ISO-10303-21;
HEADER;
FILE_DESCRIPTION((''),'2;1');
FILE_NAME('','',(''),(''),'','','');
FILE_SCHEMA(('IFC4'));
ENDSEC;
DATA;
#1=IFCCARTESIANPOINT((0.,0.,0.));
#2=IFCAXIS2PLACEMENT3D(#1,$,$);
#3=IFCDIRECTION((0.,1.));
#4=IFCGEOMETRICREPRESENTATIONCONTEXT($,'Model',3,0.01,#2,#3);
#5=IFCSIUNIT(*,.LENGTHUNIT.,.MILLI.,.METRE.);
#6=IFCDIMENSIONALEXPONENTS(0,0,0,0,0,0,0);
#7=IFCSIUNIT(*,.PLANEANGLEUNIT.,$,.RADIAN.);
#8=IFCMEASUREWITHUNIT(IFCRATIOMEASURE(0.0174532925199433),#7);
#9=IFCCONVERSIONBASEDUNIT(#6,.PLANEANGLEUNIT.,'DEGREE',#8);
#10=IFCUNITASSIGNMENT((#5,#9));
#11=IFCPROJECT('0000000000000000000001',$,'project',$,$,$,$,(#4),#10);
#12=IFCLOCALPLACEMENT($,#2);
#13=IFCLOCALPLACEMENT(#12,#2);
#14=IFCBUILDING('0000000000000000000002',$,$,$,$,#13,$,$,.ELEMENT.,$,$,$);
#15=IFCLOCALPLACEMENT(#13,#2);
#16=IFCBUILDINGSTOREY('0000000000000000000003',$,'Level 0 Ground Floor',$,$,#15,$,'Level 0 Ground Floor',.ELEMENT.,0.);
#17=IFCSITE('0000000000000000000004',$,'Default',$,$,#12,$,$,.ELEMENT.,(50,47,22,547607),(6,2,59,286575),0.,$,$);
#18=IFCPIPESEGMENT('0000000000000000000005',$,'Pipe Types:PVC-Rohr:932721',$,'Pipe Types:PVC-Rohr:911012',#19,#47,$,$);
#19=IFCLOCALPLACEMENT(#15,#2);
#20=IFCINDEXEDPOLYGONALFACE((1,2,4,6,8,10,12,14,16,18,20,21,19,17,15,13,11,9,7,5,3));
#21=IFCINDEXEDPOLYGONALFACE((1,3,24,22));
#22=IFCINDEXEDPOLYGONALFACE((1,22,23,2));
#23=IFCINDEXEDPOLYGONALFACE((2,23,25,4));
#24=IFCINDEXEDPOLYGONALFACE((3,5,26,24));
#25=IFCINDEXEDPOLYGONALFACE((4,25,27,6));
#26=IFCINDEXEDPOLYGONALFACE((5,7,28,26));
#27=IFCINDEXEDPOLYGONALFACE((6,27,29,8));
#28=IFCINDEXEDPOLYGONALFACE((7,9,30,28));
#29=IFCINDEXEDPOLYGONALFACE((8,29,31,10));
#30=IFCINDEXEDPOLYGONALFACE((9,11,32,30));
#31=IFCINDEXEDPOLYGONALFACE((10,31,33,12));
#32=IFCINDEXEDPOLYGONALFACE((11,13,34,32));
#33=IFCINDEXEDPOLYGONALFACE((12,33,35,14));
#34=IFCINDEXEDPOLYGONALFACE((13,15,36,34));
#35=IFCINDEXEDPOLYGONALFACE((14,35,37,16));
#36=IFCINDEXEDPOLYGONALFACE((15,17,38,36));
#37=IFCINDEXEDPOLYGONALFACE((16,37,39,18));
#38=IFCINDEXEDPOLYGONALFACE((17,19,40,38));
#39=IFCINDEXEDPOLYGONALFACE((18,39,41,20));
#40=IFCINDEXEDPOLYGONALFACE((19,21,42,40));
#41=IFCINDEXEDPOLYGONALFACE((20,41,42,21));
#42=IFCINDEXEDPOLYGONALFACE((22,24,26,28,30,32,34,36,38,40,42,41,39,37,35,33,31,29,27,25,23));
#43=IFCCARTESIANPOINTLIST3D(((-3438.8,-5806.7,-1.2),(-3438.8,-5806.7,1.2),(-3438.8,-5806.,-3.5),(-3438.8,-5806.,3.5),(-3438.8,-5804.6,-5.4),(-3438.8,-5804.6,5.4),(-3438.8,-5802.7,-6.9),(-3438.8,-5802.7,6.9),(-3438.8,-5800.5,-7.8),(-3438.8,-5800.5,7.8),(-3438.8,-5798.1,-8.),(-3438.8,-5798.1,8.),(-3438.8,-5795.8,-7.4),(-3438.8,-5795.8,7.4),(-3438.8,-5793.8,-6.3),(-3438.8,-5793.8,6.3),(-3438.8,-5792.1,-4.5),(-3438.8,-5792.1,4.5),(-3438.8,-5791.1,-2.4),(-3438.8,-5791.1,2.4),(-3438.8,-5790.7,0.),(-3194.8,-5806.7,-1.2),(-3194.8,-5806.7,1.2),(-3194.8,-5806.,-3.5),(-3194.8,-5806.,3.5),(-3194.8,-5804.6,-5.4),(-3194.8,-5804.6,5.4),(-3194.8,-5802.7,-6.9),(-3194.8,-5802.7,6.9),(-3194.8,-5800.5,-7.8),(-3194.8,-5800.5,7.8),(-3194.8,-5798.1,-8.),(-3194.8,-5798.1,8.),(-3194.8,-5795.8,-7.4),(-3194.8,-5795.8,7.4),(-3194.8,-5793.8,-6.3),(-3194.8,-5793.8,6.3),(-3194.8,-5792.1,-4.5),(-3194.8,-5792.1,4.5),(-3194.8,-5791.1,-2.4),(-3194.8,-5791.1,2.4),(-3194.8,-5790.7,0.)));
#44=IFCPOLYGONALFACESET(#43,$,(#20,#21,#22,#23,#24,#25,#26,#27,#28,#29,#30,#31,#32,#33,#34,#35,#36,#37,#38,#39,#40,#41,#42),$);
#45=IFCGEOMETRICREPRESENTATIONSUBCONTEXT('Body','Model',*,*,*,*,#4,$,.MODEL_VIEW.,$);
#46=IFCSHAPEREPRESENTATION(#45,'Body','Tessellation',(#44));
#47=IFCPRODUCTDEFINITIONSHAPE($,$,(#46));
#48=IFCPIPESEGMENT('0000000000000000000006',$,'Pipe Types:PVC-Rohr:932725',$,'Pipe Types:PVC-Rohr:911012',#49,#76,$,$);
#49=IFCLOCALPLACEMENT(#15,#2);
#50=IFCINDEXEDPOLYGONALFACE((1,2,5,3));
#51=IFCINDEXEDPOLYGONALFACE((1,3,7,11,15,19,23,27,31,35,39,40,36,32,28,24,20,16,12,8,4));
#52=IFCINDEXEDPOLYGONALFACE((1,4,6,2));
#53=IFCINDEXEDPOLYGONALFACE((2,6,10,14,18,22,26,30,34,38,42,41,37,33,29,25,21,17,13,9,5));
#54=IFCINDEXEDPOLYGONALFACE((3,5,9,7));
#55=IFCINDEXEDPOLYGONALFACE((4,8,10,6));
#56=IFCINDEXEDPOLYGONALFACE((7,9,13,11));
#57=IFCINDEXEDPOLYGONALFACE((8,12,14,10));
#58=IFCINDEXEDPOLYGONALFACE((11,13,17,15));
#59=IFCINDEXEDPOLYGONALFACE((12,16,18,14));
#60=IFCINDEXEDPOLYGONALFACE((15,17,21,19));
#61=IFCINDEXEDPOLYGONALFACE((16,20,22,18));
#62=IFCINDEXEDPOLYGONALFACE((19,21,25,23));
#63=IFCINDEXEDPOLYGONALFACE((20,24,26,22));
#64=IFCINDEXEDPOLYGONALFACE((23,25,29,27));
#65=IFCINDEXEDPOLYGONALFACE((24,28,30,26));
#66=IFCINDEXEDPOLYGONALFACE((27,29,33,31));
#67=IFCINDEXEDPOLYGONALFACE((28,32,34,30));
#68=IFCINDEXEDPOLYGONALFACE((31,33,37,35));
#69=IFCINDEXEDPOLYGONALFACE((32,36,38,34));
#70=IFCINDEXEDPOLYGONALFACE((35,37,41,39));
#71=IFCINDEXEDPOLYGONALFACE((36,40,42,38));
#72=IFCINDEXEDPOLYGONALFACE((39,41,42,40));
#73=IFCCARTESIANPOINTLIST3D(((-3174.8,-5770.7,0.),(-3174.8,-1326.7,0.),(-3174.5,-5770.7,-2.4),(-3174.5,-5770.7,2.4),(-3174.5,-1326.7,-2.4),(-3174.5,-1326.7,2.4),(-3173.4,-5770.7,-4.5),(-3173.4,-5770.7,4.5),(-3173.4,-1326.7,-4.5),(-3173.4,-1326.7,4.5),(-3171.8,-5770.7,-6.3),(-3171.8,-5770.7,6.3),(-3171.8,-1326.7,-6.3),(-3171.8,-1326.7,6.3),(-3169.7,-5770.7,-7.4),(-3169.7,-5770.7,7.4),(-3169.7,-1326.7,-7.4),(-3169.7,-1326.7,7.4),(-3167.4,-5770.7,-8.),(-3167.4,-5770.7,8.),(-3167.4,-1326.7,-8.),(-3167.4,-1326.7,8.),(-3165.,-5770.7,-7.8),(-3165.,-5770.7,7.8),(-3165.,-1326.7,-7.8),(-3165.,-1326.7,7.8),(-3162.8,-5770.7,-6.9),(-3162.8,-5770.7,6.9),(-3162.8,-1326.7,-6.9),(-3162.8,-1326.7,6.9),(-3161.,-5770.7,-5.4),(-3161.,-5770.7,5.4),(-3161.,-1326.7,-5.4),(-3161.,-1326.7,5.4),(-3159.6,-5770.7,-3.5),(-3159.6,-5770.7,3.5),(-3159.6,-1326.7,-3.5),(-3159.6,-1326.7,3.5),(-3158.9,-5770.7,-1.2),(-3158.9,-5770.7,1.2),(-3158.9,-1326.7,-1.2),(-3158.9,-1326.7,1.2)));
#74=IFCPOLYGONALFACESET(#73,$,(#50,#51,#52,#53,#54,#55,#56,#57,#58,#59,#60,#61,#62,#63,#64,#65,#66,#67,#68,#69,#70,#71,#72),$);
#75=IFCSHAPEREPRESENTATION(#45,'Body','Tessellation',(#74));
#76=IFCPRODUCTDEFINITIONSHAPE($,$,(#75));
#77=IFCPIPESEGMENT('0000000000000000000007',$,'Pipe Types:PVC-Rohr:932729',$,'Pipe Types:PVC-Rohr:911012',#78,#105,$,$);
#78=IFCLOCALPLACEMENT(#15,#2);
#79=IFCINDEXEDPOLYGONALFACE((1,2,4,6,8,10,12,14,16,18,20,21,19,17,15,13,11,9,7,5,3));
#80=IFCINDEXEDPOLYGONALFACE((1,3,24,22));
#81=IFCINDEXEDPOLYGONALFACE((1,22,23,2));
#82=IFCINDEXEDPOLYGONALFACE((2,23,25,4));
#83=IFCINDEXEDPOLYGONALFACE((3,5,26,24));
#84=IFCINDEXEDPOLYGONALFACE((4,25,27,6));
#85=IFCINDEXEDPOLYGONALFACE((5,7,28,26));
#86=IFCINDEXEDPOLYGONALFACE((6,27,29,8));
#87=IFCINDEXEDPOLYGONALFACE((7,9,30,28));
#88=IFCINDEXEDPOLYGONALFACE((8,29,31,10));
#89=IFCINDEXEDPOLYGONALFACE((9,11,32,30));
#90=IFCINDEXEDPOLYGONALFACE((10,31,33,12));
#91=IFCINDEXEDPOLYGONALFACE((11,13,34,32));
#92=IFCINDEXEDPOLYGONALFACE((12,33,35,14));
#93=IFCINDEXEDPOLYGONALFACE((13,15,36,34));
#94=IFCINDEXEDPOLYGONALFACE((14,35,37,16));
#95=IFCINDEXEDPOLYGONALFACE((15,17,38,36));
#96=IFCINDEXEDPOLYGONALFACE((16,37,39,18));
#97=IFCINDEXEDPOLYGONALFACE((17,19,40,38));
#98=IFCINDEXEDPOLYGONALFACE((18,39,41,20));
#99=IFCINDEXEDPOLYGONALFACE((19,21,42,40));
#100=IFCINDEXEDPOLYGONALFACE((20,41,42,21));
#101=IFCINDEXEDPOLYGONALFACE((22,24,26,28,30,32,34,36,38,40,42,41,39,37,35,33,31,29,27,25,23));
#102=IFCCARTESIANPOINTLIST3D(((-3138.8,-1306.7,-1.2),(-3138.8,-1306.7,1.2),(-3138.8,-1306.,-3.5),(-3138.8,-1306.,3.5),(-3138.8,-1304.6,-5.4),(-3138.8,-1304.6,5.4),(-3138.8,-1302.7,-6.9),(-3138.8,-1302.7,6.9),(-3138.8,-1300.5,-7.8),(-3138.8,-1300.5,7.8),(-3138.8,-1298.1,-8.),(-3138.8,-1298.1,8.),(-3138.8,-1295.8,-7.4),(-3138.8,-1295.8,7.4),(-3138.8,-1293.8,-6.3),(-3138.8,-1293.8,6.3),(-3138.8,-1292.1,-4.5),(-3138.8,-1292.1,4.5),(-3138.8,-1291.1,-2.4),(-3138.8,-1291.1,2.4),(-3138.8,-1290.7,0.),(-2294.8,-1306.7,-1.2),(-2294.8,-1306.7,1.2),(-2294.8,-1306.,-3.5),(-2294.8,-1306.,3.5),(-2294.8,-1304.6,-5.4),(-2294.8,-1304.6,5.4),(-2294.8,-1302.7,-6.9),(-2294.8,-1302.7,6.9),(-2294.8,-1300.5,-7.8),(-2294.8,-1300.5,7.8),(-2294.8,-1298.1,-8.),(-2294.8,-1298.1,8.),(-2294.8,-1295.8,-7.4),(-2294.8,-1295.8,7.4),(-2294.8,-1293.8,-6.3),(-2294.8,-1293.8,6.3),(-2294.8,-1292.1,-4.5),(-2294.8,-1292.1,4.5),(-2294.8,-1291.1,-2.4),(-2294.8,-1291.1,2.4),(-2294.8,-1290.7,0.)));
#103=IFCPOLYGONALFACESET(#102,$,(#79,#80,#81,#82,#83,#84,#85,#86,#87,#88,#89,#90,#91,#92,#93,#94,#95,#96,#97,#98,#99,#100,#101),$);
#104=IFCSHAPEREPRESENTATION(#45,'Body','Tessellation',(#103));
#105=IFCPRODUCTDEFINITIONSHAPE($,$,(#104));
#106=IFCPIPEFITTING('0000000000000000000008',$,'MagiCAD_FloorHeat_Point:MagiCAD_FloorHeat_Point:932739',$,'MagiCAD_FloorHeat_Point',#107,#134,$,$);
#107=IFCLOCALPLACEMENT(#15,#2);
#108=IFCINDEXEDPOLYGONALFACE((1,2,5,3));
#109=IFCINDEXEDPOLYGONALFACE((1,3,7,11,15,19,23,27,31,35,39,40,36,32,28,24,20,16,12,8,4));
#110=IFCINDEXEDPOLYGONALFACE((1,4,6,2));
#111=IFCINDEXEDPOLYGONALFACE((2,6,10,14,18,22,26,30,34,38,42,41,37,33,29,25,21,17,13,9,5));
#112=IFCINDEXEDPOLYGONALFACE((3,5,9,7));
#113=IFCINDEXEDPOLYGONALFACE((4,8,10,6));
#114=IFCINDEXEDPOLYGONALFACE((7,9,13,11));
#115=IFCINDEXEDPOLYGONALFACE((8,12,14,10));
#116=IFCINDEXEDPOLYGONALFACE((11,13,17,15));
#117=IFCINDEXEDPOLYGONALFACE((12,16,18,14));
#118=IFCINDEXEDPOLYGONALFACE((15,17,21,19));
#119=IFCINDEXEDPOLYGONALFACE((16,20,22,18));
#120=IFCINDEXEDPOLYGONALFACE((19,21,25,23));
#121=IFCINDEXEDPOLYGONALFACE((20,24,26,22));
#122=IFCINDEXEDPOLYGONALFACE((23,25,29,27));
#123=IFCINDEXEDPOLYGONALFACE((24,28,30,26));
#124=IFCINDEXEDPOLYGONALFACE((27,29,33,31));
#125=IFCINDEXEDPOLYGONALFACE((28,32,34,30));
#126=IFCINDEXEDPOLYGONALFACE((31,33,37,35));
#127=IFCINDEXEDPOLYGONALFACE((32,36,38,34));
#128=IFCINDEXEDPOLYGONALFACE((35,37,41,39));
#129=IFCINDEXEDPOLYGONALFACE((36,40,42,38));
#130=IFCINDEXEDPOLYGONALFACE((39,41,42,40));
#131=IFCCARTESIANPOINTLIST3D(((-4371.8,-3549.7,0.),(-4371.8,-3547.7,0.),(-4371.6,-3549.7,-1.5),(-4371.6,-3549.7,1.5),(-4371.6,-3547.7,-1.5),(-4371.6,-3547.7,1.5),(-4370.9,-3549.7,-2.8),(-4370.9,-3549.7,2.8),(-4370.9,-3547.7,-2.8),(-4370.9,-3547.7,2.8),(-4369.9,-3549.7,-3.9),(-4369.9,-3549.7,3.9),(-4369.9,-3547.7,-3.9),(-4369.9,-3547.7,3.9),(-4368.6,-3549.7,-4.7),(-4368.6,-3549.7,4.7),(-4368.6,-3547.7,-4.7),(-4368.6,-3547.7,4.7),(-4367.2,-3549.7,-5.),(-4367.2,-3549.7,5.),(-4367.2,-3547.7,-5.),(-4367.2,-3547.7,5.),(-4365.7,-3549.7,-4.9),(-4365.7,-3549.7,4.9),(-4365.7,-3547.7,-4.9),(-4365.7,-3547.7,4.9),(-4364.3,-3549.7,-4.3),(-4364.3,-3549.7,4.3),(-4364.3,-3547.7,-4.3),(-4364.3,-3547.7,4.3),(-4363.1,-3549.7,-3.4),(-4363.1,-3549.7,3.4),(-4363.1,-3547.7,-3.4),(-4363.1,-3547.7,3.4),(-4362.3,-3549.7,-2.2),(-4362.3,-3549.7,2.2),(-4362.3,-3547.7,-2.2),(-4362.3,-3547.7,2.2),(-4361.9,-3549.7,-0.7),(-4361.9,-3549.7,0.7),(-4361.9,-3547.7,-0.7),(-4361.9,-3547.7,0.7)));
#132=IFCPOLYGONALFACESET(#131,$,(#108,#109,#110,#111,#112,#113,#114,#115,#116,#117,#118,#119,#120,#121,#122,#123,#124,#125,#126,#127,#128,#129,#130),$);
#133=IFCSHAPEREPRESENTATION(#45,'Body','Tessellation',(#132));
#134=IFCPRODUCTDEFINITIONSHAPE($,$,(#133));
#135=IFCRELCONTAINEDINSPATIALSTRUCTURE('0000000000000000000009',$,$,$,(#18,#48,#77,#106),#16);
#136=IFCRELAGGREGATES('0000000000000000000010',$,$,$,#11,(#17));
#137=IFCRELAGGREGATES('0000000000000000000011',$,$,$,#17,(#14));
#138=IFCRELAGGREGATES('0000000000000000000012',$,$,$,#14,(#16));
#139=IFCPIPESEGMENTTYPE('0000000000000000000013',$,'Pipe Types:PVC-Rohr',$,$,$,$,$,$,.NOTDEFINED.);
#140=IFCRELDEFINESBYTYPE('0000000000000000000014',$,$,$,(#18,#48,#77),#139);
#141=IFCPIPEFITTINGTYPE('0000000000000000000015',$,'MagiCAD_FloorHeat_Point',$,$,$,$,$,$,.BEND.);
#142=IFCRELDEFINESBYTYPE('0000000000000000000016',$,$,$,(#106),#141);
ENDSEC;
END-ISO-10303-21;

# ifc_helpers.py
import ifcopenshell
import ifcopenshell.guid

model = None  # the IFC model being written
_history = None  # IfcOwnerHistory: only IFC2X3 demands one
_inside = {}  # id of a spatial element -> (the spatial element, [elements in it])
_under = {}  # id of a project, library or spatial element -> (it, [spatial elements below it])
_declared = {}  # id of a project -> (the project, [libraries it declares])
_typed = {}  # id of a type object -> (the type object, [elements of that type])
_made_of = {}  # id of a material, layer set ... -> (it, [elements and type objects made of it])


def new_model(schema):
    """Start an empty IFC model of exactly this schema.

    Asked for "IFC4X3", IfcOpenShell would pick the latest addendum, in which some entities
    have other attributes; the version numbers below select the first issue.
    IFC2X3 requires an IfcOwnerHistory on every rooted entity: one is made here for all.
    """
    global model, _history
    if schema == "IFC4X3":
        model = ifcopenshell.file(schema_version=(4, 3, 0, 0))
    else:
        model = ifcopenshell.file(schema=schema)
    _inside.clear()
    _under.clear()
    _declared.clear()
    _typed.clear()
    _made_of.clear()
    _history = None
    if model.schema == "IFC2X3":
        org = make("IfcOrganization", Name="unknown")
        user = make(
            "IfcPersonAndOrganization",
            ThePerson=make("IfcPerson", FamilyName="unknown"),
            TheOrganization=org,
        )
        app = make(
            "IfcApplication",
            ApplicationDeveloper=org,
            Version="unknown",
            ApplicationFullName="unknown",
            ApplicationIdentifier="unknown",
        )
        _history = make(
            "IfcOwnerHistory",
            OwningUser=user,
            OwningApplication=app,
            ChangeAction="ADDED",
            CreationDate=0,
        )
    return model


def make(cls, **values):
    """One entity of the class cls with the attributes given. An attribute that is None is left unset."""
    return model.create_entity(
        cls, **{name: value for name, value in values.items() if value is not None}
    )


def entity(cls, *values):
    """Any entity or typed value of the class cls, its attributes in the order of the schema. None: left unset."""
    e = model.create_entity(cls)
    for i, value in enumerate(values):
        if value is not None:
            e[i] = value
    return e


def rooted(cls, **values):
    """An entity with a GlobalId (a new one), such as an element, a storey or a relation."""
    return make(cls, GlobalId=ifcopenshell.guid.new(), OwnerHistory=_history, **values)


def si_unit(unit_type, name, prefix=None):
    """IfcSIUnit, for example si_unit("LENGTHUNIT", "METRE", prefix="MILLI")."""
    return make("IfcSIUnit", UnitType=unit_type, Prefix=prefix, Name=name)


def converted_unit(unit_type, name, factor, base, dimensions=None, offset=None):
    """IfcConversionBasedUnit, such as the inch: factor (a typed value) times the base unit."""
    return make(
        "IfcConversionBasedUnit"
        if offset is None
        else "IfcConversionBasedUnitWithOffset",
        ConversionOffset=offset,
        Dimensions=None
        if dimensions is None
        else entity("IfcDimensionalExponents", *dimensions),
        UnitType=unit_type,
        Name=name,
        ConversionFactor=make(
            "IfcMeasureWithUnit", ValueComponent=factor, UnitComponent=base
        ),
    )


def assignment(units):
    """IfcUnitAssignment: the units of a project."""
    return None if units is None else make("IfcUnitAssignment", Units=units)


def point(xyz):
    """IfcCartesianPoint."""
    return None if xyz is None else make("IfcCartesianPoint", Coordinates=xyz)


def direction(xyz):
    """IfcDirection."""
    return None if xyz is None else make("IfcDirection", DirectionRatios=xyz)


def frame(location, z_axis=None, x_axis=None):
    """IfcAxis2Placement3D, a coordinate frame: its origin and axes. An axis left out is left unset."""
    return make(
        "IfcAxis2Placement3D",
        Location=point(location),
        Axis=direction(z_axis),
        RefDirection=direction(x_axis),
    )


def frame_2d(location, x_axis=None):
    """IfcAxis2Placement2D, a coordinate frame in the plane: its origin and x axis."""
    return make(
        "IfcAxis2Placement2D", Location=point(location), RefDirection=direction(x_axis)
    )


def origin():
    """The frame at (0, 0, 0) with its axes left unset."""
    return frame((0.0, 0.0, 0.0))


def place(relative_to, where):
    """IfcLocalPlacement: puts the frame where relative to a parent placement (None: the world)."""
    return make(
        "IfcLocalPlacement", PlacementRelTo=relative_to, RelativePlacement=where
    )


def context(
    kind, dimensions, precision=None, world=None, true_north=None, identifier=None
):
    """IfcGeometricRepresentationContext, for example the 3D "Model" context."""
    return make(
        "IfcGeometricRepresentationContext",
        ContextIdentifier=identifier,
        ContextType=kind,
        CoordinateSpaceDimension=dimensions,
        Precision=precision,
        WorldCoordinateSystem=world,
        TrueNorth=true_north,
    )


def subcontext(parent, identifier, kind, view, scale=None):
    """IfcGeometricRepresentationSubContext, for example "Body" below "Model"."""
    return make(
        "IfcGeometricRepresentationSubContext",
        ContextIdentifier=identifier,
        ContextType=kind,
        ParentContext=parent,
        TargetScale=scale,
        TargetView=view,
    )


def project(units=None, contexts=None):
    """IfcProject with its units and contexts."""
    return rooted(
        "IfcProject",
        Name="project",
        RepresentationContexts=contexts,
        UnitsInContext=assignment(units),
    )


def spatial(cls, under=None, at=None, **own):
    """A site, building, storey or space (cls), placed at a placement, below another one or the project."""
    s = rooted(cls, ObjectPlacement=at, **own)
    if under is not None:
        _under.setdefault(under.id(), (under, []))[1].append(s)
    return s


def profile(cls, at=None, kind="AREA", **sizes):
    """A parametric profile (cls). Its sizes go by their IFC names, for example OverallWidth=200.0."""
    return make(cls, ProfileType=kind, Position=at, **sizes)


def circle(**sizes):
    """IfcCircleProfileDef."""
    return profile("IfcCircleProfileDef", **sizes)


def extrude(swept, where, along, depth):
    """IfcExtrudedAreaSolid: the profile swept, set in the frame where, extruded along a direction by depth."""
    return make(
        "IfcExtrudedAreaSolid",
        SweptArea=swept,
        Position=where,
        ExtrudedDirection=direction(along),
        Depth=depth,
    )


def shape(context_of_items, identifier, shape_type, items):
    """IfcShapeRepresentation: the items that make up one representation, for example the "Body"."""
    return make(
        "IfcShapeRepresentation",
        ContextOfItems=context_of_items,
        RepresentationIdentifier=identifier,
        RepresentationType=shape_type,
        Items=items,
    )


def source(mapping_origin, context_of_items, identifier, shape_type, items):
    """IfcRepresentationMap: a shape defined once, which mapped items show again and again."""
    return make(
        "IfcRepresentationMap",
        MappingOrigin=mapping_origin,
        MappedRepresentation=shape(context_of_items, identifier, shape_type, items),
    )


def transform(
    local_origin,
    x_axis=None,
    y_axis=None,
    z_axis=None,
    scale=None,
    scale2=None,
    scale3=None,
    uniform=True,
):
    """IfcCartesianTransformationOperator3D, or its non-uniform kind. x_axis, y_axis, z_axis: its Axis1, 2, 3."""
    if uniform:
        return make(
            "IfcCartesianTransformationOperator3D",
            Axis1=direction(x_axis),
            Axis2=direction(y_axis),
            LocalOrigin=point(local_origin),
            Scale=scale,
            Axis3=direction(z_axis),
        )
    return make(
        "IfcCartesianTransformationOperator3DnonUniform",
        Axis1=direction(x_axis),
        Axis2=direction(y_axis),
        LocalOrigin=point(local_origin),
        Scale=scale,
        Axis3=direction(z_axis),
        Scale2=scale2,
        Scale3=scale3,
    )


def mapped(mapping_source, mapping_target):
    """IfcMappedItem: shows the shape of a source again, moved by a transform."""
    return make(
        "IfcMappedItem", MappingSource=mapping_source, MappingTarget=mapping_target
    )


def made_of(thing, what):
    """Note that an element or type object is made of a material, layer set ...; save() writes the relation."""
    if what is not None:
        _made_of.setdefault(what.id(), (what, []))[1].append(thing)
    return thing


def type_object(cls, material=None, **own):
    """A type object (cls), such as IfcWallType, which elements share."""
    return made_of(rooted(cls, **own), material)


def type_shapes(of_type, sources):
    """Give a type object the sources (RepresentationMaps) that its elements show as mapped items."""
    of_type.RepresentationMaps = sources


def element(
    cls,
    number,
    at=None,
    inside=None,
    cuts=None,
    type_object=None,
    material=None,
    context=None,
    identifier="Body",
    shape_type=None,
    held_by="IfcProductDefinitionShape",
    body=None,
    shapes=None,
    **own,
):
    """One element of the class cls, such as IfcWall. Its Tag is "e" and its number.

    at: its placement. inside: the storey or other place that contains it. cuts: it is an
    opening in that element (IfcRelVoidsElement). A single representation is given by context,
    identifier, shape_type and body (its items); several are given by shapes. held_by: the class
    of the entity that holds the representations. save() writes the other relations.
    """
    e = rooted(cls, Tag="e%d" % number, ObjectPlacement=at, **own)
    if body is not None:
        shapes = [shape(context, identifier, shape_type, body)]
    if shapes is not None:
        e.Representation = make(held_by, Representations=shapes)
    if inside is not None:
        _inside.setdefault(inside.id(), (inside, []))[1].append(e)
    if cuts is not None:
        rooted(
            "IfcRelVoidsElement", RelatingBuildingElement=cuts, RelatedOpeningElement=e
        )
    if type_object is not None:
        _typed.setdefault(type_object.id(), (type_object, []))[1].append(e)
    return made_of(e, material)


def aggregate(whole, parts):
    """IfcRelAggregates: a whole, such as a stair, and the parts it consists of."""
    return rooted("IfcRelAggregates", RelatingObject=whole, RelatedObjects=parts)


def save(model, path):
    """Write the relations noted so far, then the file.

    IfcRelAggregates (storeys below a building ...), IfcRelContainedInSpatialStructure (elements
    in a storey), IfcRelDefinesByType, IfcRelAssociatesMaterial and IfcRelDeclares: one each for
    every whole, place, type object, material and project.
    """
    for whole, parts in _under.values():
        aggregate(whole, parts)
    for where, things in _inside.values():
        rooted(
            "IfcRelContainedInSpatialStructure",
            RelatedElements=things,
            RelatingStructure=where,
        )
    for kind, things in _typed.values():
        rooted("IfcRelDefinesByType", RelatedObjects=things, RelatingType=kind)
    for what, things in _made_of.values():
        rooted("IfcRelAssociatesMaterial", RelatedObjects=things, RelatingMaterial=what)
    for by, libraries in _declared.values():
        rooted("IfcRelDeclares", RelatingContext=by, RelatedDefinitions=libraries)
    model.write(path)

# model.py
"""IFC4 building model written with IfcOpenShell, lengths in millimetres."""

from ifc_helpers import new_model, entity, si_unit, converted_unit, direction, frame, frame_2d, origin, place, context, subcontext, project, spatial, circle, extrude, source, transform, mapped, type_object, type_shapes, element, save


model = new_model("IFC4")

# Units and contexts
model_context = context("Model", 3, precision=0.01, world=origin(), true_north=direction((0.0, 1.0)))
body_context = subcontext(model_context, "Body", "Model", "MODEL_VIEW")
ifc_project = project(units=[si_unit("LENGTHUNIT", "METRE", prefix="MILLI"), converted_unit("PLANEANGLEUNIT", "DEGREE", entity("IfcRatioMeasure", 0.0174532925199433), si_unit("PLANEANGLEUNIT", "RADIAN"), dimensions=[0, 0, 0, 0, 0, 0, 0])], contexts=[model_context])

# Site, building, storey
site_placement = place(None, origin())
site = spatial("IfcSite", under=ifc_project, at=site_placement, Name="Default", CompositionType="ELEMENT", RefLatitude=(50, 47, 22, 547607), RefLongitude=(6, 2, 59, 286575), RefElevation=0.0)
building_placement = place(site_placement, origin())
building = spatial("IfcBuilding", under=site, at=building_placement, CompositionType="ELEMENT")
storey_placement = place(building_placement, origin())
storey = spatial("IfcBuildingStorey", under=building, at=storey_placement, Name="Level 0 Ground Floor", LongName="Level 0 Ground Floor", CompositionType="ELEMENT", Elevation=0.0)

# Pipe segments
pipe_segment_type = type_object("IfcPipeSegmentType", Name="Pipe Types:PVC-Rohr", PredefinedType="NOTDEFINED")
pipe_segment_1_placement = place(storey_placement, frame((-3438.8, -5808.3, -9.6)))
element("IfcPipeSegment", 1, at=pipe_segment_1_placement, inside=storey, type_object=pipe_segment_type, Name="Pipe Types:PVC-Rohr:932721", ObjectType="Pipe Types:PVC-Rohr:911012", context=body_context, shape_type="SweptSolid", body=[
    extrude(circle(Radius=8.0, at=frame_2d((0.0, 0.0), x_axis=(1.0, 0.0))), frame((0.0, 9.6, 9.6), z_axis=(1.0, 0.0, 0.0), x_axis=(0.0, 1.0, 0.0)), (0.0, 0.0, 1.0), 244.0),
])
pipe_segment_2_placement = place(storey_placement, frame((-3176.4, -5770.7, -9.6)))
element("IfcPipeSegment", 2, at=pipe_segment_2_placement, inside=storey, type_object=pipe_segment_type, Name="Pipe Types:PVC-Rohr:932725", ObjectType="Pipe Types:PVC-Rohr:911012", context=body_context, shape_type="SweptSolid", body=[
    extrude(circle(Radius=8.0, at=frame_2d((0.0, 0.0), x_axis=(1.0, 0.0))), frame((9.6, 0.0, 9.6), z_axis=(0.0, 1.0, 0.0), x_axis=(-1.0, 0.0, 0.0)), (0.0, 0.0, 1.0), 4444.0),
])
pipe_segment_3_placement = place(storey_placement, frame((-3138.8, -1308.3, -9.6)))
element("IfcPipeSegment", 3, at=pipe_segment_3_placement, inside=storey, type_object=pipe_segment_type, Name="Pipe Types:PVC-Rohr:932729", ObjectType="Pipe Types:PVC-Rohr:911012", context=body_context, shape_type="SweptSolid", body=[
    extrude(circle(Radius=8.0, at=frame_2d((0.0, 0.0), x_axis=(1.0, 0.0))), frame((0.0, 9.6, 9.6), z_axis=(1.0, 0.0, 0.0), x_axis=(0.0, 1.0, 0.0)), (0.0, 0.0, 1.0), 844.0),
])

# Pipe fitting
pipe_fitting_type = type_object("IfcPipeFittingType", Name="MagiCAD_FloorHeat_Point", PredefinedType="BEND")
shared_shape = source(origin(), body_context, "Body", "SweptSolid", [
    extrude(circle(Radius=5.0, at=frame_2d((0.0, 0.0), x_axis=(1.0, 0.0))), frame((-1.0, 0.0, 0.0), z_axis=(1.0, 0.0, 0.0), x_axis=(0.0, 1.0, 0.0)), (0.0, 0.0, 1.0), 2.0),
])
type_shapes(pipe_fitting_type, [shared_shape])
pipe_fitting_placement = place(storey_placement, frame((-4366.8, -3548.7, 0.0), z_axis=(0.0, 0.0, 1.0), x_axis=(0.0, 1.0, 0.0)))
element("IfcPipeFitting", 4, at=pipe_fitting_placement, inside=storey, type_object=pipe_fitting_type, Name="MagiCAD_FloorHeat_Point:MagiCAD_FloorHeat_Point:932739", ObjectType="MagiCAD_FloorHeat_Point", context=body_context, shape_type="MappedRepresentation", body=[
    mapped(shared_shape, transform((0.0, 0.0, 0.0), scale=1.0)),
])

save(model, "model.ifc")
